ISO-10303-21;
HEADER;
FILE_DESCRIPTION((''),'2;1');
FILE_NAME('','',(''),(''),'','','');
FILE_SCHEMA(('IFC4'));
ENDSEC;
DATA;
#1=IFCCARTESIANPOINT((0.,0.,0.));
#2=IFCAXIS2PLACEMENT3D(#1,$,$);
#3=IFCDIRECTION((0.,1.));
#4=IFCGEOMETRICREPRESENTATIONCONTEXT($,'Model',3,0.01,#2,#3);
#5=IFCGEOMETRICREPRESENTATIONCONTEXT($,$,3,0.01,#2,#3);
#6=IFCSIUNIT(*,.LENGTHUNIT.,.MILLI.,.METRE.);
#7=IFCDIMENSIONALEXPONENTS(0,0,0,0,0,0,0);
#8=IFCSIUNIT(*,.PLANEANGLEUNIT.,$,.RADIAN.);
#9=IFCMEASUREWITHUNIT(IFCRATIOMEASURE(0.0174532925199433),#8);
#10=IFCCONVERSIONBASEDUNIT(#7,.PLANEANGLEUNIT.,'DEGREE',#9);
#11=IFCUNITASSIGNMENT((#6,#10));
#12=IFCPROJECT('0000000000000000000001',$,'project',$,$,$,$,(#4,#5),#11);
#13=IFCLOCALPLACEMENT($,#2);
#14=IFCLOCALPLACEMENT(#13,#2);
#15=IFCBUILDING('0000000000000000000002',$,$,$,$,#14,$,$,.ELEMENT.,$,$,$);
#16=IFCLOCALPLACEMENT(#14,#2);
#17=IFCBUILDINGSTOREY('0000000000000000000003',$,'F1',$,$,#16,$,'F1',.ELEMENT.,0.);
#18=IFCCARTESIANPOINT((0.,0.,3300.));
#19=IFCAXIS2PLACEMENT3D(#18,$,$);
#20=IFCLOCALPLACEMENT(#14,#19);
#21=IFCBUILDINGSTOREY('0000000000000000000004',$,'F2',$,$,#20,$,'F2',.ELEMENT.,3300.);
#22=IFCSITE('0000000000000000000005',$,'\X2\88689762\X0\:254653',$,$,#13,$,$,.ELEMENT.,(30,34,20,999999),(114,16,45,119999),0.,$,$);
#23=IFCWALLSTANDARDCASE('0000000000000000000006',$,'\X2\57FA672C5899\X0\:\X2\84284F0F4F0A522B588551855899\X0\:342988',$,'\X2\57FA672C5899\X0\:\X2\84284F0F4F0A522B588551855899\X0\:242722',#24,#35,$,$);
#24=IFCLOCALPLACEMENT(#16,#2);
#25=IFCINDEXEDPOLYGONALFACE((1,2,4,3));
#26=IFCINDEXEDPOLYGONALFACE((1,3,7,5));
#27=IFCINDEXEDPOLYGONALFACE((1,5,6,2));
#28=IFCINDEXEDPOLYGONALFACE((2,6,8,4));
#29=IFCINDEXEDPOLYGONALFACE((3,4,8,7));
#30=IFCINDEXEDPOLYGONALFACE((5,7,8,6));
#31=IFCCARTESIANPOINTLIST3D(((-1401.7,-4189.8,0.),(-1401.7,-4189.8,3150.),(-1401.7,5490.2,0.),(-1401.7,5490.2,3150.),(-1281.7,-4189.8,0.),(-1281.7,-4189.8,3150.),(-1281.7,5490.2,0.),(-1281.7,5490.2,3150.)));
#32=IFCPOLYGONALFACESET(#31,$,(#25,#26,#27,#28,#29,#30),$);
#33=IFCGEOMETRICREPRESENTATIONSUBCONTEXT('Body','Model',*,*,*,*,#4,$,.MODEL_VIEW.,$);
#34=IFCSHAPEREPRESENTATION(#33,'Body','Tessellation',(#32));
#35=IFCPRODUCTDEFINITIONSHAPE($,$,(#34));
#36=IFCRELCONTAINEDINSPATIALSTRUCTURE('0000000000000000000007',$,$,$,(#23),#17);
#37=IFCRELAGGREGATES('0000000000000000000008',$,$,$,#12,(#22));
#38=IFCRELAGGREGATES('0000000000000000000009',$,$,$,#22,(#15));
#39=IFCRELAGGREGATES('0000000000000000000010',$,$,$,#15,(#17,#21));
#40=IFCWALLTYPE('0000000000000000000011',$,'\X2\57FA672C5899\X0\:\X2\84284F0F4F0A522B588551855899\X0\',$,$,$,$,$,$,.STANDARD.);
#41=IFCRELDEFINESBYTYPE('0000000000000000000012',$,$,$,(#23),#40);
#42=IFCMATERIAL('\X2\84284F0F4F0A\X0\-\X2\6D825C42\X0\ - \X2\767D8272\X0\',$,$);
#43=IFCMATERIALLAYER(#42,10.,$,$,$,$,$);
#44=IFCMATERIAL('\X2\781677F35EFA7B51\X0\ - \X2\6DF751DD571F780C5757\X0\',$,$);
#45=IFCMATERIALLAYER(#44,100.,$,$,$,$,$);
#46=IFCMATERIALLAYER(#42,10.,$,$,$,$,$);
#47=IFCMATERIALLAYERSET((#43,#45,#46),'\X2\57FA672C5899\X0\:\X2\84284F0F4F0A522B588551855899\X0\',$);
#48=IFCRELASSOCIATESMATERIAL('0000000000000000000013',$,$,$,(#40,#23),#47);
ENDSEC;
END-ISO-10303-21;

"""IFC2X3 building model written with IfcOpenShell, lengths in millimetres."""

from ifc_helpers import new_model, entity, si_unit, converted_unit, direction, frame, frame_2d, origin, place, context, subcontext, project, spatial, polyline, rectangle, extrude, clip, bounded_halfspace, material, layer, layer_set, layer_usage, type_object, element, save


model = new_model("IFC2X3")

# Units and contexts
model_context = context("Model", 3, precision=0.01, world=origin(), true_north=direction((0.0, 1.0)))
context_of_model = context(None, 3, precision=0.01, world=origin(), true_north=direction((0.0, 1.0)))
body_context = subcontext(model_context, "Body", "Model", "MODEL_VIEW")
ifc_project = project(units=[si_unit("LENGTHUNIT", "METRE", prefix="MILLI"), converted_unit("PLANEANGLEUNIT", "DEGREE", entity("IfcRatioMeasure", 0.0174532925199433), si_unit("PLANEANGLEUNIT", "RADIAN"), dimensions=[0, 0, 0, 0, 0, 0, 0])], contexts=[model_context, context_of_model])

# Site, building, storey
site_placement = place(None, origin())
site = spatial("IfcSite", under=ifc_project, at=site_placement, Name="表面:254653", CompositionType="ELEMENT", RefLatitude=(30, 34, 20, 999999), RefLongitude=(114, 16, 45, 119999), RefElevation=0.0)
building_placement = place(site_placement, origin())
building = spatial("IfcBuilding", under=site, at=building_placement, CompositionType="ELEMENT")
storey_1_placement = place(building_placement, origin())
storey_1 = spatial("IfcBuildingStorey", under=building, at=storey_1_placement, Name="F1", LongName="F1", CompositionType="ELEMENT", Elevation=0.0)

# Shared definitions
ifc_material_1 = material(Name="萨伏伊-涂层 - 白色")
ifc_layer_1 = layer(ifc_material_1, 10.0)
ifc_material_2 = material(Name="砖石建筑 - 混凝土砌块")
ifc_layer_2 = layer(ifc_material_2, 100.0)
ifc_layer_3 = layer(ifc_material_1, 10.0)
ifc_layer_set = layer_set([ifc_layer_1, ifc_layer_2, ifc_layer_3], Name="基本墙:萨伏伊别墅内墙")
wall_type = type_object("IfcWallType", Name="基本墙:萨伏伊别墅内墙", PredefinedType="STANDARD", material=ifc_layer_set)

# Shared definitions
storey_2_placement = place(building_placement, frame((0.0, 0.0, 3300.0)))
storey_2 = spatial("IfcBuildingStorey", under=building, at=storey_2_placement, Name="F2", LongName="F2", CompositionType="ELEMENT", Elevation=3300.0)

# Wall
ifc_layer_usage_1 = layer_usage(ifc_layer_set, "AXIS2", "NEGATIVE", 60.0)
wall_1_placement = place(storey_1_placement, frame((-1341.7, -4189.8, 0.0), z_axis=(0.0, 0.0, 1.0), x_axis=(0.0, 1.0, 0.0)))
element("IfcWallStandardCase", 1, at=wall_1_placement, inside=storey_1, type_object=wall_type, material=ifc_layer_usage_1, Name="基本墙:萨伏伊别墅内墙:342988", ObjectType="基本墙:萨伏伊别墅内墙:242722", context=body_context, shape_type="Clipping", body=[
    clip(extrude(rectangle(XDim=9680.0, YDim=120.0, at=frame_2d((4840.0, 0.0), x_axis=(-1.0, 0.0))), origin(), (0.0, 0.0, 1.0), 3150.0), bounded_halfspace(frame((0.0, -60.0, 3150.0), z_axis=(0.0, 0.0, -1.0), x_axis=(-1.0, 0.0, 0.0)), True, frame((0.0, -60.0, 3150.0)), polyline([(0.0, 0.0), (9680.0, 0.0), (9680.0, 120.0), (0.0, 120.0), (0.0, 0.0)]))),
])

save(model, "model.ifc")
